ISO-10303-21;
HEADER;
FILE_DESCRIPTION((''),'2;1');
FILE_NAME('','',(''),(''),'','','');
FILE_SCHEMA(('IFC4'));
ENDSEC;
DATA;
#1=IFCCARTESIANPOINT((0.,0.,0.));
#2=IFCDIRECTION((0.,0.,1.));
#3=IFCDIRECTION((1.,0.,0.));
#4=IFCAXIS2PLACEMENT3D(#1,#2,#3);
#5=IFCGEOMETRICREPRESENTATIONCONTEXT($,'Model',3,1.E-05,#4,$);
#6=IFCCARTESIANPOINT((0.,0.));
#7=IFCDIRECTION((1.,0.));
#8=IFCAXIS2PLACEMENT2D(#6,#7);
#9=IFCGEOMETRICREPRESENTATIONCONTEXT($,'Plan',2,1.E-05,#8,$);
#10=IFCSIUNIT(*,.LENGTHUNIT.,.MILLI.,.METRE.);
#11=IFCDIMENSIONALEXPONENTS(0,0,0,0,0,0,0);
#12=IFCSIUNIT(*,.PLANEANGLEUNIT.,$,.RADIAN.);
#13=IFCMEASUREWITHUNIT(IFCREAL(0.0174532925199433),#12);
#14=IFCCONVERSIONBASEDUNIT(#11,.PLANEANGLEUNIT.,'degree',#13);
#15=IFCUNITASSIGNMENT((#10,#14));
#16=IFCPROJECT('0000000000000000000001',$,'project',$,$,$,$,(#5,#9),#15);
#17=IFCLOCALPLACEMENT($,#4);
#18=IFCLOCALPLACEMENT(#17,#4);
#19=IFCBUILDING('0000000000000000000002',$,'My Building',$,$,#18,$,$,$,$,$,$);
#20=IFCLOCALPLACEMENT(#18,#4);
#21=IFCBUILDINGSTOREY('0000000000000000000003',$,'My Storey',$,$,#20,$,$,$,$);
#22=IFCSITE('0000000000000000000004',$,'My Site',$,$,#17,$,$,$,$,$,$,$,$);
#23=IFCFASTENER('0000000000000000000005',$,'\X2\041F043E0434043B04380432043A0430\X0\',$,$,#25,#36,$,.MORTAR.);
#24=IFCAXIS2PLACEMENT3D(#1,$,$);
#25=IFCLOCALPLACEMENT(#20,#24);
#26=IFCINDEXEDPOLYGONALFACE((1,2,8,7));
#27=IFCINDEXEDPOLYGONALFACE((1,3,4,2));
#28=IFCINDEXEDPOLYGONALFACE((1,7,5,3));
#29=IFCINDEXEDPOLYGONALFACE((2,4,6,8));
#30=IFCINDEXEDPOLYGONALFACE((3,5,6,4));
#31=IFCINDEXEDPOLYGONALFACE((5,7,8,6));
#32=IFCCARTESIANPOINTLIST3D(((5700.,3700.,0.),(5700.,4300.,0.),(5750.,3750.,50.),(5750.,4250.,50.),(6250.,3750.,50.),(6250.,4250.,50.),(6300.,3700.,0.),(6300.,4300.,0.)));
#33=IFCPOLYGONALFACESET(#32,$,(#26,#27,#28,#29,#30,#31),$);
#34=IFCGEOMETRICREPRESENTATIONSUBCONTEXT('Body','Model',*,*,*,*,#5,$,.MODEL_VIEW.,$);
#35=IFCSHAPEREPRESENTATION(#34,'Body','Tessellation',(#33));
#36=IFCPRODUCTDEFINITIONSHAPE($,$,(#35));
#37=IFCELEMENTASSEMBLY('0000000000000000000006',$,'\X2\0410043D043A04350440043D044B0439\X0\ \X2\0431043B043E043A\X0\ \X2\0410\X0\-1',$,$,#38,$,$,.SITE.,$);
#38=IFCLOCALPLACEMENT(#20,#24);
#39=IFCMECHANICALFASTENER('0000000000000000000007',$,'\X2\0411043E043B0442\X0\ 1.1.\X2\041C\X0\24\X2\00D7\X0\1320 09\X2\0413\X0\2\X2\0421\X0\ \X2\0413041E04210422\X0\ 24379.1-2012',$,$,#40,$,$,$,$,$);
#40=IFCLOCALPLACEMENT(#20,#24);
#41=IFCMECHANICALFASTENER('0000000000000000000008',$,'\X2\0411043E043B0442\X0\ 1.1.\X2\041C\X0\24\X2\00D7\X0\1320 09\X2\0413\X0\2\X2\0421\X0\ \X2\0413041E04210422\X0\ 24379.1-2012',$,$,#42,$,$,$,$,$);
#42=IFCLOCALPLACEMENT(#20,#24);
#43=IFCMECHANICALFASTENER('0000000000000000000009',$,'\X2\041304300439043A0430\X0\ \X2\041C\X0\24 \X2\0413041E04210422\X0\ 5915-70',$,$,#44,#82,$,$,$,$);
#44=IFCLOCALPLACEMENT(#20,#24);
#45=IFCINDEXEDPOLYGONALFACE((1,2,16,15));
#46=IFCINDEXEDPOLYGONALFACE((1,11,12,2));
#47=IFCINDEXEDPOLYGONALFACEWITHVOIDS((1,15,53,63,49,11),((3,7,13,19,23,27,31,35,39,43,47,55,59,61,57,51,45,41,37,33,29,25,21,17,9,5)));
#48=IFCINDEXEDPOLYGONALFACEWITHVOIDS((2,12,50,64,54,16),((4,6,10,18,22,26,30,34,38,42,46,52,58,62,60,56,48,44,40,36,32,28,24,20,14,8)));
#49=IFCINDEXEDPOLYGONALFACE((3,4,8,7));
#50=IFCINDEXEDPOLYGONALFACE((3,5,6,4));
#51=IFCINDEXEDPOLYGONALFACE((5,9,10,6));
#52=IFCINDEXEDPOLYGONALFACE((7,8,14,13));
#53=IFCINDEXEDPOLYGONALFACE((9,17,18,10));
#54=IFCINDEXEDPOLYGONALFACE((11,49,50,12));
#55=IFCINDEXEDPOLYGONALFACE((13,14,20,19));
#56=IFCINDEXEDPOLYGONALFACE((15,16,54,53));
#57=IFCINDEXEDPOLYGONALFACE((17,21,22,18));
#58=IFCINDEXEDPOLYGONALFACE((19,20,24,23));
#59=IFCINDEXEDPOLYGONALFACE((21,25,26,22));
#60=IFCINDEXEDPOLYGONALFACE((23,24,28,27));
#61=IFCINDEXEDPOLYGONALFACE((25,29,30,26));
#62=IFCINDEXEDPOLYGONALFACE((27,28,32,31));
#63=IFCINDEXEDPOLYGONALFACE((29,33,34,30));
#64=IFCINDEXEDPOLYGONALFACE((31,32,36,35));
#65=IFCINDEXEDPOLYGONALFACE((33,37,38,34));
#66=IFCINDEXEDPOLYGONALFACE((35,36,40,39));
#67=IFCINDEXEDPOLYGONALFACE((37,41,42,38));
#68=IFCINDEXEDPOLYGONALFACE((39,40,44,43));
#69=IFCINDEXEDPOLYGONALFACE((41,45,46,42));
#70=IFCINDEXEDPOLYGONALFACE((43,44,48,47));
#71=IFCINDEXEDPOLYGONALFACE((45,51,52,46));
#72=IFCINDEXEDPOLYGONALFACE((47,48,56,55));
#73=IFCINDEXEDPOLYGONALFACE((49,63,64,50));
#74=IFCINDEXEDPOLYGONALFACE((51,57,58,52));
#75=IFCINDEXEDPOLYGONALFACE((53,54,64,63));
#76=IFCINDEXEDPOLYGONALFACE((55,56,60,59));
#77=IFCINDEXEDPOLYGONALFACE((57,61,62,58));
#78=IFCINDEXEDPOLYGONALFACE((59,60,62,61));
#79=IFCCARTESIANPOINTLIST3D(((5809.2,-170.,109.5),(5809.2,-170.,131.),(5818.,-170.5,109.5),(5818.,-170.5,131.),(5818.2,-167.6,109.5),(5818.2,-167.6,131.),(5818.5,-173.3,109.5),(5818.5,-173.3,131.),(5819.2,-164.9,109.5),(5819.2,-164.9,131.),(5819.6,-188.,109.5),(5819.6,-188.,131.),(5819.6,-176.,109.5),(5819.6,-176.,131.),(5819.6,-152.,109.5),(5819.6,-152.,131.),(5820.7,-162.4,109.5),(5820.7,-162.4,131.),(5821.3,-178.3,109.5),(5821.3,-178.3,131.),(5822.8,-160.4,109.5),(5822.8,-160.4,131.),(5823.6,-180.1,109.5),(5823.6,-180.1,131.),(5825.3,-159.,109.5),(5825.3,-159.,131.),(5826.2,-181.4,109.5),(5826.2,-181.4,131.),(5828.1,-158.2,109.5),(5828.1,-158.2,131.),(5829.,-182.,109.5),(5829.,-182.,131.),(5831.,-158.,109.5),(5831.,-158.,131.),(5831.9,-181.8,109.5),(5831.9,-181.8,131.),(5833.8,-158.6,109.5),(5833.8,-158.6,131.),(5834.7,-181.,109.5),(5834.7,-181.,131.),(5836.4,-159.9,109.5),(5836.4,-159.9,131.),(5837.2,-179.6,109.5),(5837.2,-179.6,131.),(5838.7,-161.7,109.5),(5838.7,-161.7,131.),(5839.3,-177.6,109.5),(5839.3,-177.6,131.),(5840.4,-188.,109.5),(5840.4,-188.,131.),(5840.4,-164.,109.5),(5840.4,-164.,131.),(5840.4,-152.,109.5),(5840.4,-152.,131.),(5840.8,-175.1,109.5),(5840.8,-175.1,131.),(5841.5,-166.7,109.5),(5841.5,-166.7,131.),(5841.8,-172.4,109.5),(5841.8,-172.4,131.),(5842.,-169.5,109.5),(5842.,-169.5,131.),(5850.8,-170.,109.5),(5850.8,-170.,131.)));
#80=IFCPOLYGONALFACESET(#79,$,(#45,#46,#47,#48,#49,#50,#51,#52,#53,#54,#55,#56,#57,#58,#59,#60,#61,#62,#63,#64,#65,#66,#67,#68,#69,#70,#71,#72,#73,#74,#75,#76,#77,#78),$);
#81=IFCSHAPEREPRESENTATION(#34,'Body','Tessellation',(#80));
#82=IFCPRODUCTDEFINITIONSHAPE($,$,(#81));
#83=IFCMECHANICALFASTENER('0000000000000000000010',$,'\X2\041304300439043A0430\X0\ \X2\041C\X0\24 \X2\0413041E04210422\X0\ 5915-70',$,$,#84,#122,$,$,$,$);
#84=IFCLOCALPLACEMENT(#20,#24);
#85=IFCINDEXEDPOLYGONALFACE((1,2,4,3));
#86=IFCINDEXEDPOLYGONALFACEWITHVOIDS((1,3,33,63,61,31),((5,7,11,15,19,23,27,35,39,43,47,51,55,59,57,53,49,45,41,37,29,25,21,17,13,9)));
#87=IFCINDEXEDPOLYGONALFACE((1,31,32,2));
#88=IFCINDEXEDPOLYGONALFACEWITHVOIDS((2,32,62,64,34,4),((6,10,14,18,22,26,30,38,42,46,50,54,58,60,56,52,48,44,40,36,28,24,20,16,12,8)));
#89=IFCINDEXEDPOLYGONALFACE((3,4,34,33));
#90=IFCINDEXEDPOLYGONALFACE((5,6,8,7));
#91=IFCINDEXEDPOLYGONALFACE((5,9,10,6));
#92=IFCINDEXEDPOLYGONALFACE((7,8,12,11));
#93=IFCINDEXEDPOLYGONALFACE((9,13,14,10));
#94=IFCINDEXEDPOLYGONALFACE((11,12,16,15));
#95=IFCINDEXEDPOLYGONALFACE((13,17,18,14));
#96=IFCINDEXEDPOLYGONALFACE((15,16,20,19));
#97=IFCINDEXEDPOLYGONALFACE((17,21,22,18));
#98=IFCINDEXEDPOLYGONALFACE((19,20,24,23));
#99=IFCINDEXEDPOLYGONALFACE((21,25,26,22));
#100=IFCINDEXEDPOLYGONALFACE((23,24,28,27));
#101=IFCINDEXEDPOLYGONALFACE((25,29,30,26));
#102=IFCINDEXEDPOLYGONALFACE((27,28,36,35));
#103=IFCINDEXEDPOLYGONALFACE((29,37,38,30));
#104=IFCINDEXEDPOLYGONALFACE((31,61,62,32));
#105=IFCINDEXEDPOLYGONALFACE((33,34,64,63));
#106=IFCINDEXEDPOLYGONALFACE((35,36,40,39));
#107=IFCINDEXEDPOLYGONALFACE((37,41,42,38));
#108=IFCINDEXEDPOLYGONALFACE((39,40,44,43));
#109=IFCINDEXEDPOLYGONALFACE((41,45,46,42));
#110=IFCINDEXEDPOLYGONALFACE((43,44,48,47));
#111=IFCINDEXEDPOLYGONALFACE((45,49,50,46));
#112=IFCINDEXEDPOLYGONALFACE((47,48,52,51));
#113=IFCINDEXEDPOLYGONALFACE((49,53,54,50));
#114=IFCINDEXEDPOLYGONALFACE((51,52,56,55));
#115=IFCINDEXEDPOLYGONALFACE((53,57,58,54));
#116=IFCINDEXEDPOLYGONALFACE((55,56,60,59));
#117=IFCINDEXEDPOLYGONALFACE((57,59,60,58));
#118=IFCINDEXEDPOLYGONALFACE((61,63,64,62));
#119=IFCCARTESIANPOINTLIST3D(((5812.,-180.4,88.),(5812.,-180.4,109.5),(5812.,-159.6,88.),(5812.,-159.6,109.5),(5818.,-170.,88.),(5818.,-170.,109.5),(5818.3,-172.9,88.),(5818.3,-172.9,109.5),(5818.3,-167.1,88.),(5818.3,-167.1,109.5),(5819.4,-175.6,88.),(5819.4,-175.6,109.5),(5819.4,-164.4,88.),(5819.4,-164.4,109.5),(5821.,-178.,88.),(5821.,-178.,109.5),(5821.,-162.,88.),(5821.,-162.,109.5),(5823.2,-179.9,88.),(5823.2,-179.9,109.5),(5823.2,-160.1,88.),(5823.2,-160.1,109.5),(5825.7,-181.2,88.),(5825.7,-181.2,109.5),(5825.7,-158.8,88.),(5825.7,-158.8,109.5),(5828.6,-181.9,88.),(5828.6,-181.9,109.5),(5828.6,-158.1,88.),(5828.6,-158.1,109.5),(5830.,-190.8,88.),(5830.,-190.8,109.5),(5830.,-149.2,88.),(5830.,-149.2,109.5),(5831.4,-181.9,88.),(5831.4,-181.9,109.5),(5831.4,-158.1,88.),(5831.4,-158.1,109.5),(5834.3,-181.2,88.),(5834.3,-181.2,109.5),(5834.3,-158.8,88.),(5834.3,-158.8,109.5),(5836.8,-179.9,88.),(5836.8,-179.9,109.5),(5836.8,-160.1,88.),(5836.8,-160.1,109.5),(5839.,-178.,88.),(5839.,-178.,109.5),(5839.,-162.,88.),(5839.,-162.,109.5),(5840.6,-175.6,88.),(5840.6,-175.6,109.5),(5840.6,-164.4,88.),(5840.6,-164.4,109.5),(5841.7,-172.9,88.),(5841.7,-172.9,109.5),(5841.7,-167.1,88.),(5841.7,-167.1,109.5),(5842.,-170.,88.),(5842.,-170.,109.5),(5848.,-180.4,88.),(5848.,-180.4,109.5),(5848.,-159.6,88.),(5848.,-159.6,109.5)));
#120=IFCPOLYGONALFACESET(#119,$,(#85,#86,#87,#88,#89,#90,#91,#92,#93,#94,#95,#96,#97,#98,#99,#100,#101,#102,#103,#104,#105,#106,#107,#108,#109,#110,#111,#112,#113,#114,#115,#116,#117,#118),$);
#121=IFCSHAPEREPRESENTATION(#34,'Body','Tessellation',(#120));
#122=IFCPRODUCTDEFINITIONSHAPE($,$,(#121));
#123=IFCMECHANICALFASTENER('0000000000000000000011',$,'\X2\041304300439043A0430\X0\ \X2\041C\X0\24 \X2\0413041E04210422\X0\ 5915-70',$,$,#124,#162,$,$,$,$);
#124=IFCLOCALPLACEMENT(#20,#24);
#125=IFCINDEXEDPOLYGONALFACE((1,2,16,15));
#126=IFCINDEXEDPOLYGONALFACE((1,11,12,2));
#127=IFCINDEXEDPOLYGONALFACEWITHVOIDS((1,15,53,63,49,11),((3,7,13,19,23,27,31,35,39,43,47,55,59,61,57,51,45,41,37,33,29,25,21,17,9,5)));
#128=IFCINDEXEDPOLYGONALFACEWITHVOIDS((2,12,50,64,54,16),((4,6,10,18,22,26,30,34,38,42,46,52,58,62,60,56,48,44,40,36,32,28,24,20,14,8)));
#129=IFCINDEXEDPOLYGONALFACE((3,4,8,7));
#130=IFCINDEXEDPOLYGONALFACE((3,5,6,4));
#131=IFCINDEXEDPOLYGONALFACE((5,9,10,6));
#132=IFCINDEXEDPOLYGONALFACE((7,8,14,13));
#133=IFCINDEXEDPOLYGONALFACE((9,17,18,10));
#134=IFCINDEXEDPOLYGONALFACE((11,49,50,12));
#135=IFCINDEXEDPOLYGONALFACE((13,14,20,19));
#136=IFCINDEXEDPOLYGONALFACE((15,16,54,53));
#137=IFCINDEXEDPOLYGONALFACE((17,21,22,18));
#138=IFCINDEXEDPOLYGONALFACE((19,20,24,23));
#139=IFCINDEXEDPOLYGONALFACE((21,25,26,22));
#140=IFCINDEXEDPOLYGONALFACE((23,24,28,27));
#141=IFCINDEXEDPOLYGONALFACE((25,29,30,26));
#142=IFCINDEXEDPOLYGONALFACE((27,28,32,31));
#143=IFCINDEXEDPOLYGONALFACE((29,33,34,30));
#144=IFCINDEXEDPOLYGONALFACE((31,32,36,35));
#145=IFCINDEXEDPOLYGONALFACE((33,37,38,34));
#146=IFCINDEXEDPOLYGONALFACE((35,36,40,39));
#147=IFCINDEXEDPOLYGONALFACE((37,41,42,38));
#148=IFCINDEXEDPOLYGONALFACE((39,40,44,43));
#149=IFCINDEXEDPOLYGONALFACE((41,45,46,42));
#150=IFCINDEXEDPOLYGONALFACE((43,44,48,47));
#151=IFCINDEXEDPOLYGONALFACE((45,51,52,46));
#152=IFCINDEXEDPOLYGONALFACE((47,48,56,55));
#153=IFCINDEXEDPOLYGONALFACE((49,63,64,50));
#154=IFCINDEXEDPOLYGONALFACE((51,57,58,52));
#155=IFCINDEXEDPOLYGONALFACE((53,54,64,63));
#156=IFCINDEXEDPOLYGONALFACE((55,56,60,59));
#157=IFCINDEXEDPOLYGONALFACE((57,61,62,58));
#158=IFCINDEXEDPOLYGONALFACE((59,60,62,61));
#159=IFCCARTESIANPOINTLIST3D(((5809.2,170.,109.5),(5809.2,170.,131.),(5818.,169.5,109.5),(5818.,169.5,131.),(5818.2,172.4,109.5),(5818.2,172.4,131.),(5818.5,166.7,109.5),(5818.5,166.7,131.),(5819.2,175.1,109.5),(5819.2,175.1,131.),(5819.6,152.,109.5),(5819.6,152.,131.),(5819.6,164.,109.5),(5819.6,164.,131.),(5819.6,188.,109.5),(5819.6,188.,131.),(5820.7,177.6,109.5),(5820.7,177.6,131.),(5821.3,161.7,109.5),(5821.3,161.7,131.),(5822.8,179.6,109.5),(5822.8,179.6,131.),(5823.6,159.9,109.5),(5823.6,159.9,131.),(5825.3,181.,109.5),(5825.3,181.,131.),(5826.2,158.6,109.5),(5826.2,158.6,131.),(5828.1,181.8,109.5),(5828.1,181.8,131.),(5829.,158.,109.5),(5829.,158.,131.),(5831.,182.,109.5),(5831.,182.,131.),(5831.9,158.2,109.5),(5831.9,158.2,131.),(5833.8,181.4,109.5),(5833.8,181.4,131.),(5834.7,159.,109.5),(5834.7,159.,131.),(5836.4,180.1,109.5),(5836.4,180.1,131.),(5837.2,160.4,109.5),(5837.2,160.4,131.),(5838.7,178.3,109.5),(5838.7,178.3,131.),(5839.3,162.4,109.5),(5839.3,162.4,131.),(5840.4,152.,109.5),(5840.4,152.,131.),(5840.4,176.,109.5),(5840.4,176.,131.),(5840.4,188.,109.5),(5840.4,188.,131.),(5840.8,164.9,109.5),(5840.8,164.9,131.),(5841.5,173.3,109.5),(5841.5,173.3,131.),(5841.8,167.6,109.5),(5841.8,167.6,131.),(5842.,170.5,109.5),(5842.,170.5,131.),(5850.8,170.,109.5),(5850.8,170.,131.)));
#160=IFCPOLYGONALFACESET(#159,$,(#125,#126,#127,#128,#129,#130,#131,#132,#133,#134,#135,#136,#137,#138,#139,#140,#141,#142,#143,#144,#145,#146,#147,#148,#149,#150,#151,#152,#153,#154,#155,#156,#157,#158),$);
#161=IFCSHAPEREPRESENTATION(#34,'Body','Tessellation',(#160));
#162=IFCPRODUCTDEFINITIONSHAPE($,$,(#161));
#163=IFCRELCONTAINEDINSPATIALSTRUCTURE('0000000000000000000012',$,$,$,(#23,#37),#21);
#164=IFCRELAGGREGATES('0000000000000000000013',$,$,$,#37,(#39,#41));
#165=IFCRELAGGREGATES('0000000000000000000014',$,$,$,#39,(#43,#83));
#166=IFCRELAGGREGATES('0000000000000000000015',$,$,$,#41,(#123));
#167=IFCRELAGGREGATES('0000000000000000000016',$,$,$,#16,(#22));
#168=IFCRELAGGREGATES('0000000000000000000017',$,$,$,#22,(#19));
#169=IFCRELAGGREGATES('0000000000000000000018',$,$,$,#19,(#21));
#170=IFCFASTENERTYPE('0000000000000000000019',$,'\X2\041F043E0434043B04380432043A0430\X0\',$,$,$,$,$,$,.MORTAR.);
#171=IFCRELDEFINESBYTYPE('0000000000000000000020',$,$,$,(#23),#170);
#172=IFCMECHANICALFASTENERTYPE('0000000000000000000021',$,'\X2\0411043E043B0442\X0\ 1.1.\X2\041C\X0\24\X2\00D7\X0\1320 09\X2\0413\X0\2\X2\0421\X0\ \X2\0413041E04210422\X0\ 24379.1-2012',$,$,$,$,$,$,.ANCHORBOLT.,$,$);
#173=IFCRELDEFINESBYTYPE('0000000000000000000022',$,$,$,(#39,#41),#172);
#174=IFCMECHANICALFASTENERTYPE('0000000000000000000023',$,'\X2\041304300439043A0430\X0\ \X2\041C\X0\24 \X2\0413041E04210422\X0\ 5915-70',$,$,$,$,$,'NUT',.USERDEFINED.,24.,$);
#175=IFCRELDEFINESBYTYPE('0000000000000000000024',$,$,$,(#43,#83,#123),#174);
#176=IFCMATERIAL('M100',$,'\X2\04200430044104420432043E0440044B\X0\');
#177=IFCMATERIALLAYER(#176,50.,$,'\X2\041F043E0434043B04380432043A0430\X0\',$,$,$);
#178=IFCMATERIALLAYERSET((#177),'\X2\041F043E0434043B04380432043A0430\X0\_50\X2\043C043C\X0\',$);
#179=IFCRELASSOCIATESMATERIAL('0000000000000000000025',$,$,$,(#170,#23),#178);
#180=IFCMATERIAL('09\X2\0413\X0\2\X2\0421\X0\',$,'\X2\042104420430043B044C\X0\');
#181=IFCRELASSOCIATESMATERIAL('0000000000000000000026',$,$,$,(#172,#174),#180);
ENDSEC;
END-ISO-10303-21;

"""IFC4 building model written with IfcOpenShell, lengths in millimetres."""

from ifc_helpers import new_model, entity, si_unit, converted_unit, frame, origin_with_axes, origin_2d_with_axis, place, context, subcontext, project, spatial, polyline, line, indexed_curve, outline, extrude, clip, halfspace, source, transform, mapped, material, layer, layer_set, layer_usage, type_object, type_shapes, element, aggregate, save


model = new_model("IFC4")

# Units and contexts
model_context = context("Model", 3, precision=1e-05, world=origin_with_axes())
plan_context = context("Plan", 2, precision=1e-05, world=origin_2d_with_axis())
body_context = subcontext(model_context, "Body", "Model", "MODEL_VIEW")
ifc_project = project(units=[si_unit("LENGTHUNIT", "METRE", prefix="MILLI"), converted_unit("PLANEANGLEUNIT", "degree", entity("IfcReal", 0.0174532925199433), si_unit("PLANEANGLEUNIT", "RADIAN"), dimensions=[0, 0, 0, 0, 0, 0, 0])], contexts=[model_context, plan_context])

# Site, building, storey
site_placement = place(None, origin_with_axes())
site = spatial("IfcSite", under=ifc_project, at=site_placement, Name="My Site")
building_placement = place(site_placement, origin_with_axes())
building = spatial("IfcBuilding", under=site, at=building_placement, Name="My Building")
storey_placement = place(building_placement, origin_with_axes())
storey = spatial("IfcBuildingStorey", under=building, at=storey_placement, Name="My Storey")

# Fastener
ifc_material_1 = material(Name="M100", Category="Растворы")
ifc_layer_1 = layer(ifc_material_1, 50.0, Name="Подливка")
ifc_layer_set_1 = layer_set([ifc_layer_1], Name="Подливка_50мм")
ifc_layer_usage_1 = layer_usage(ifc_layer_set_1, "AXIS3", "POSITIVE", 0.0)
fastener_type = type_object("IfcFastenerType", Name="Подливка", PredefinedType="MORTAR", material=ifc_layer_set_1)
fastener_1_placement = place(storey_placement, frame((6000.0, 4000.0, 0.0), z_axis=(0.0, 0.0, 1.0), x_axis=(1.0, 0.0, 0.0)))
element("IfcFastener", 1, at=fastener_1_placement, inside=storey, type_object=fastener_type, material=ifc_layer_usage_1, Name="Подливка", PredefinedType="MORTAR", context=body_context, shape_type="Clipping", body=[
    clip(clip(clip(clip(extrude(outline(indexed_curve([(-300.0, -300.0), (300.0, -300.0), (300.0, 300.0), (-300.0, 300.0)], segments=[line(3, 2), line(2, 1), line(1, 4), line(4, 3)], self_intersect=False)), None, (0.0, 0.0, 1.0), 50.0), halfspace(frame((-53.6, 200.0, 353.6), z_axis=(0.707107, 0.0, 0.707107), x_axis=(0.707107, 0.0, -0.707107)), False)), halfspace(frame((-200.0, -53.6, 353.6), z_axis=(0.0, 0.707107, 0.707107), x_axis=(0.0, 0.707107, -0.707107)), False)), halfspace(frame((200.0, 53.6, 353.6), z_axis=(0.0, -0.707107, 0.707107), x_axis=(0.0, -0.707107, -0.707107)), False)), halfspace(frame((53.6, 200.0, 353.6), z_axis=(-0.707107, 0.0, 0.707107), x_axis=(-0.707107, 0.0, -0.707107)), False)),
])

# Element assembly, mechanical fasteners
assembly_1_placement = place(storey_placement, frame((6000.0, 0.0, 0.0), z_axis=(0.0, 0.0, 1.0), x_axis=(1.0, 0.0, 0.0)))
assembly_1 = element("IfcElementAssembly", 2, at=assembly_1_placement, inside=storey, Name="Анкерный блок А-1", AssemblyPlace="SITE")
ifc_material_2 = material(Name="09Г2С", Category="Сталь")
mechanical_fastener_type_1 = type_object("IfcMechanicalFastenerType", Name="Болт 1.1.М24×1320 09Г2С ГОСТ 24379.1-2012", PredefinedType="ANCHORBOLT", material=ifc_material_2)
mechanical_fastener_1_placement = place(assembly_1_placement, frame((-170.0, -170.0, 0.0), z_axis=(0.0, 0.0, 1.0), x_axis=(1.0, 0.0, 0.0)))
mechanical_fastener_1 = element("IfcMechanicalFastener", 3, at=mechanical_fastener_1_placement, type_object=mechanical_fastener_type_1, Name="Болт 1.1.М24×1320 09Г2С ГОСТ 24379.1-2012")
mechanical_fastener_2_placement = place(assembly_1_placement, frame((-170.0, 170.0, 0.0), z_axis=(0.0, 0.0, 1.0), x_axis=(-1.0, 0.0, 0.0)))
mechanical_fastener_2 = element("IfcMechanicalFastener", 4, at=mechanical_fastener_2_placement, type_object=mechanical_fastener_type_1, Name="Болт 1.1.М24×1320 09Г2С ГОСТ 24379.1-2012")
aggregate(assembly_1, [mechanical_fastener_1, mechanical_fastener_2])

# Mechanical fasteners
mechanical_fastener_type_2 = type_object("IfcMechanicalFastenerType", Name="Гайка М24 ГОСТ 5915-70", ElementType="NUT", NominalDiameter=24.0, PredefinedType="USERDEFINED", material=ifc_material_2)
shared_shape_1 = source(origin_with_axes(), body_context, "Body", "SweptSolid", [
    extrude(outline(polyline([(-10.4, -18.0), (10.4, -18.0), (20.8, 0.0), (10.4, 18.0), (-10.4, 18.0), (-20.8, 0.0), (-10.4, -18.0)]), holes=[polyline([(-8.0, 9.0), (-5.6, 10.6), (-2.9, 11.7), (0.0, 12.0), (2.9, 11.7), (5.6, 10.6), (8.0, 9.0), (9.9, 6.8), (11.2, 4.3), (11.9, 1.4), (11.9, -1.4), (11.2, -4.3), (9.9, -6.8), (8.0, -9.0), (5.6, -10.6), (2.9, -11.7), (0.0, -12.0), (-2.9, -11.7), (-5.6, -10.6), (-8.0, -9.0), (-9.9, -6.8), (-11.2, -4.3), (-11.9, -1.4), (-11.9, 1.4), (-11.2, 4.3), (-9.9, 6.8), (-8.0, 9.0)])]), frame((0.0, 0.0, 0.0), z_axis=(0.0, 0.0, 1.0), x_axis=(0.0, 1.0, 0.0)), (0.0, 0.0, 1.0), 21.5),
])
type_shapes(mechanical_fastener_type_2, [shared_shape_1])
mechanical_fastener_3_placement = place(mechanical_fastener_1_placement, frame((0.0, 0.0, 109.5), z_axis=(0.0, 0.0, 1.0), x_axis=(0.866025, 0.5, 0.0)))
mechanical_fastener_3 = element("IfcMechanicalFastener", 5, at=mechanical_fastener_3_placement, type_object=mechanical_fastener_type_2, Name="Гайка М24 ГОСТ 5915-70", context=body_context, shape_type="MappedRepresentation", body=[
    mapped(shared_shape_1, transform((0.0, 0.0, 0.0), x_axis=(1.0, 0.0, 0.0), y_axis=(0.0, 1.0, 0.0), z_axis=(0.0, 0.0, 1.0), scale=1.0)),
])
mechanical_fastener_4_placement = place(mechanical_fastener_1_placement, frame((0.0, 0.0, 88.0), z_axis=(0.0, 0.0, 1.0), x_axis=(1.0, 0.0, 0.0)))
mechanical_fastener_4 = element("IfcMechanicalFastener", 6, at=mechanical_fastener_4_placement, type_object=mechanical_fastener_type_2, Name="Гайка М24 ГОСТ 5915-70", context=body_context, shape_type="MappedRepresentation", body=[
    mapped(shared_shape_1, transform((0.0, 0.0, 0.0), x_axis=(1.0, 0.0, 0.0), y_axis=(0.0, 1.0, 0.0), z_axis=(0.0, 0.0, 1.0), scale=1.0)),
])
mechanical_fastener_5_placement = place(mechanical_fastener_2_placement, frame((0.0, 0.0, 109.5), z_axis=(0.0, 0.0, 1.0), x_axis=(0.866025, 0.5, 0.0)))
mechanical_fastener_5 = element("IfcMechanicalFastener", 7, at=mechanical_fastener_5_placement, type_object=mechanical_fastener_type_2, Name="Гайка М24 ГОСТ 5915-70", context=body_context, shape_type="MappedRepresentation", body=[
    mapped(shared_shape_1, transform((0.0, 0.0, 0.0), x_axis=(1.0, 0.0, 0.0), y_axis=(0.0, 1.0, 0.0), z_axis=(0.0, 0.0, 1.0), scale=1.0)),
])
aggregate(mechanical_fastener_1, [mechanical_fastener_3, mechanical_fastener_4])
aggregate(mechanical_fastener_2, [mechanical_fastener_5])

save(model, "model.ifc")
